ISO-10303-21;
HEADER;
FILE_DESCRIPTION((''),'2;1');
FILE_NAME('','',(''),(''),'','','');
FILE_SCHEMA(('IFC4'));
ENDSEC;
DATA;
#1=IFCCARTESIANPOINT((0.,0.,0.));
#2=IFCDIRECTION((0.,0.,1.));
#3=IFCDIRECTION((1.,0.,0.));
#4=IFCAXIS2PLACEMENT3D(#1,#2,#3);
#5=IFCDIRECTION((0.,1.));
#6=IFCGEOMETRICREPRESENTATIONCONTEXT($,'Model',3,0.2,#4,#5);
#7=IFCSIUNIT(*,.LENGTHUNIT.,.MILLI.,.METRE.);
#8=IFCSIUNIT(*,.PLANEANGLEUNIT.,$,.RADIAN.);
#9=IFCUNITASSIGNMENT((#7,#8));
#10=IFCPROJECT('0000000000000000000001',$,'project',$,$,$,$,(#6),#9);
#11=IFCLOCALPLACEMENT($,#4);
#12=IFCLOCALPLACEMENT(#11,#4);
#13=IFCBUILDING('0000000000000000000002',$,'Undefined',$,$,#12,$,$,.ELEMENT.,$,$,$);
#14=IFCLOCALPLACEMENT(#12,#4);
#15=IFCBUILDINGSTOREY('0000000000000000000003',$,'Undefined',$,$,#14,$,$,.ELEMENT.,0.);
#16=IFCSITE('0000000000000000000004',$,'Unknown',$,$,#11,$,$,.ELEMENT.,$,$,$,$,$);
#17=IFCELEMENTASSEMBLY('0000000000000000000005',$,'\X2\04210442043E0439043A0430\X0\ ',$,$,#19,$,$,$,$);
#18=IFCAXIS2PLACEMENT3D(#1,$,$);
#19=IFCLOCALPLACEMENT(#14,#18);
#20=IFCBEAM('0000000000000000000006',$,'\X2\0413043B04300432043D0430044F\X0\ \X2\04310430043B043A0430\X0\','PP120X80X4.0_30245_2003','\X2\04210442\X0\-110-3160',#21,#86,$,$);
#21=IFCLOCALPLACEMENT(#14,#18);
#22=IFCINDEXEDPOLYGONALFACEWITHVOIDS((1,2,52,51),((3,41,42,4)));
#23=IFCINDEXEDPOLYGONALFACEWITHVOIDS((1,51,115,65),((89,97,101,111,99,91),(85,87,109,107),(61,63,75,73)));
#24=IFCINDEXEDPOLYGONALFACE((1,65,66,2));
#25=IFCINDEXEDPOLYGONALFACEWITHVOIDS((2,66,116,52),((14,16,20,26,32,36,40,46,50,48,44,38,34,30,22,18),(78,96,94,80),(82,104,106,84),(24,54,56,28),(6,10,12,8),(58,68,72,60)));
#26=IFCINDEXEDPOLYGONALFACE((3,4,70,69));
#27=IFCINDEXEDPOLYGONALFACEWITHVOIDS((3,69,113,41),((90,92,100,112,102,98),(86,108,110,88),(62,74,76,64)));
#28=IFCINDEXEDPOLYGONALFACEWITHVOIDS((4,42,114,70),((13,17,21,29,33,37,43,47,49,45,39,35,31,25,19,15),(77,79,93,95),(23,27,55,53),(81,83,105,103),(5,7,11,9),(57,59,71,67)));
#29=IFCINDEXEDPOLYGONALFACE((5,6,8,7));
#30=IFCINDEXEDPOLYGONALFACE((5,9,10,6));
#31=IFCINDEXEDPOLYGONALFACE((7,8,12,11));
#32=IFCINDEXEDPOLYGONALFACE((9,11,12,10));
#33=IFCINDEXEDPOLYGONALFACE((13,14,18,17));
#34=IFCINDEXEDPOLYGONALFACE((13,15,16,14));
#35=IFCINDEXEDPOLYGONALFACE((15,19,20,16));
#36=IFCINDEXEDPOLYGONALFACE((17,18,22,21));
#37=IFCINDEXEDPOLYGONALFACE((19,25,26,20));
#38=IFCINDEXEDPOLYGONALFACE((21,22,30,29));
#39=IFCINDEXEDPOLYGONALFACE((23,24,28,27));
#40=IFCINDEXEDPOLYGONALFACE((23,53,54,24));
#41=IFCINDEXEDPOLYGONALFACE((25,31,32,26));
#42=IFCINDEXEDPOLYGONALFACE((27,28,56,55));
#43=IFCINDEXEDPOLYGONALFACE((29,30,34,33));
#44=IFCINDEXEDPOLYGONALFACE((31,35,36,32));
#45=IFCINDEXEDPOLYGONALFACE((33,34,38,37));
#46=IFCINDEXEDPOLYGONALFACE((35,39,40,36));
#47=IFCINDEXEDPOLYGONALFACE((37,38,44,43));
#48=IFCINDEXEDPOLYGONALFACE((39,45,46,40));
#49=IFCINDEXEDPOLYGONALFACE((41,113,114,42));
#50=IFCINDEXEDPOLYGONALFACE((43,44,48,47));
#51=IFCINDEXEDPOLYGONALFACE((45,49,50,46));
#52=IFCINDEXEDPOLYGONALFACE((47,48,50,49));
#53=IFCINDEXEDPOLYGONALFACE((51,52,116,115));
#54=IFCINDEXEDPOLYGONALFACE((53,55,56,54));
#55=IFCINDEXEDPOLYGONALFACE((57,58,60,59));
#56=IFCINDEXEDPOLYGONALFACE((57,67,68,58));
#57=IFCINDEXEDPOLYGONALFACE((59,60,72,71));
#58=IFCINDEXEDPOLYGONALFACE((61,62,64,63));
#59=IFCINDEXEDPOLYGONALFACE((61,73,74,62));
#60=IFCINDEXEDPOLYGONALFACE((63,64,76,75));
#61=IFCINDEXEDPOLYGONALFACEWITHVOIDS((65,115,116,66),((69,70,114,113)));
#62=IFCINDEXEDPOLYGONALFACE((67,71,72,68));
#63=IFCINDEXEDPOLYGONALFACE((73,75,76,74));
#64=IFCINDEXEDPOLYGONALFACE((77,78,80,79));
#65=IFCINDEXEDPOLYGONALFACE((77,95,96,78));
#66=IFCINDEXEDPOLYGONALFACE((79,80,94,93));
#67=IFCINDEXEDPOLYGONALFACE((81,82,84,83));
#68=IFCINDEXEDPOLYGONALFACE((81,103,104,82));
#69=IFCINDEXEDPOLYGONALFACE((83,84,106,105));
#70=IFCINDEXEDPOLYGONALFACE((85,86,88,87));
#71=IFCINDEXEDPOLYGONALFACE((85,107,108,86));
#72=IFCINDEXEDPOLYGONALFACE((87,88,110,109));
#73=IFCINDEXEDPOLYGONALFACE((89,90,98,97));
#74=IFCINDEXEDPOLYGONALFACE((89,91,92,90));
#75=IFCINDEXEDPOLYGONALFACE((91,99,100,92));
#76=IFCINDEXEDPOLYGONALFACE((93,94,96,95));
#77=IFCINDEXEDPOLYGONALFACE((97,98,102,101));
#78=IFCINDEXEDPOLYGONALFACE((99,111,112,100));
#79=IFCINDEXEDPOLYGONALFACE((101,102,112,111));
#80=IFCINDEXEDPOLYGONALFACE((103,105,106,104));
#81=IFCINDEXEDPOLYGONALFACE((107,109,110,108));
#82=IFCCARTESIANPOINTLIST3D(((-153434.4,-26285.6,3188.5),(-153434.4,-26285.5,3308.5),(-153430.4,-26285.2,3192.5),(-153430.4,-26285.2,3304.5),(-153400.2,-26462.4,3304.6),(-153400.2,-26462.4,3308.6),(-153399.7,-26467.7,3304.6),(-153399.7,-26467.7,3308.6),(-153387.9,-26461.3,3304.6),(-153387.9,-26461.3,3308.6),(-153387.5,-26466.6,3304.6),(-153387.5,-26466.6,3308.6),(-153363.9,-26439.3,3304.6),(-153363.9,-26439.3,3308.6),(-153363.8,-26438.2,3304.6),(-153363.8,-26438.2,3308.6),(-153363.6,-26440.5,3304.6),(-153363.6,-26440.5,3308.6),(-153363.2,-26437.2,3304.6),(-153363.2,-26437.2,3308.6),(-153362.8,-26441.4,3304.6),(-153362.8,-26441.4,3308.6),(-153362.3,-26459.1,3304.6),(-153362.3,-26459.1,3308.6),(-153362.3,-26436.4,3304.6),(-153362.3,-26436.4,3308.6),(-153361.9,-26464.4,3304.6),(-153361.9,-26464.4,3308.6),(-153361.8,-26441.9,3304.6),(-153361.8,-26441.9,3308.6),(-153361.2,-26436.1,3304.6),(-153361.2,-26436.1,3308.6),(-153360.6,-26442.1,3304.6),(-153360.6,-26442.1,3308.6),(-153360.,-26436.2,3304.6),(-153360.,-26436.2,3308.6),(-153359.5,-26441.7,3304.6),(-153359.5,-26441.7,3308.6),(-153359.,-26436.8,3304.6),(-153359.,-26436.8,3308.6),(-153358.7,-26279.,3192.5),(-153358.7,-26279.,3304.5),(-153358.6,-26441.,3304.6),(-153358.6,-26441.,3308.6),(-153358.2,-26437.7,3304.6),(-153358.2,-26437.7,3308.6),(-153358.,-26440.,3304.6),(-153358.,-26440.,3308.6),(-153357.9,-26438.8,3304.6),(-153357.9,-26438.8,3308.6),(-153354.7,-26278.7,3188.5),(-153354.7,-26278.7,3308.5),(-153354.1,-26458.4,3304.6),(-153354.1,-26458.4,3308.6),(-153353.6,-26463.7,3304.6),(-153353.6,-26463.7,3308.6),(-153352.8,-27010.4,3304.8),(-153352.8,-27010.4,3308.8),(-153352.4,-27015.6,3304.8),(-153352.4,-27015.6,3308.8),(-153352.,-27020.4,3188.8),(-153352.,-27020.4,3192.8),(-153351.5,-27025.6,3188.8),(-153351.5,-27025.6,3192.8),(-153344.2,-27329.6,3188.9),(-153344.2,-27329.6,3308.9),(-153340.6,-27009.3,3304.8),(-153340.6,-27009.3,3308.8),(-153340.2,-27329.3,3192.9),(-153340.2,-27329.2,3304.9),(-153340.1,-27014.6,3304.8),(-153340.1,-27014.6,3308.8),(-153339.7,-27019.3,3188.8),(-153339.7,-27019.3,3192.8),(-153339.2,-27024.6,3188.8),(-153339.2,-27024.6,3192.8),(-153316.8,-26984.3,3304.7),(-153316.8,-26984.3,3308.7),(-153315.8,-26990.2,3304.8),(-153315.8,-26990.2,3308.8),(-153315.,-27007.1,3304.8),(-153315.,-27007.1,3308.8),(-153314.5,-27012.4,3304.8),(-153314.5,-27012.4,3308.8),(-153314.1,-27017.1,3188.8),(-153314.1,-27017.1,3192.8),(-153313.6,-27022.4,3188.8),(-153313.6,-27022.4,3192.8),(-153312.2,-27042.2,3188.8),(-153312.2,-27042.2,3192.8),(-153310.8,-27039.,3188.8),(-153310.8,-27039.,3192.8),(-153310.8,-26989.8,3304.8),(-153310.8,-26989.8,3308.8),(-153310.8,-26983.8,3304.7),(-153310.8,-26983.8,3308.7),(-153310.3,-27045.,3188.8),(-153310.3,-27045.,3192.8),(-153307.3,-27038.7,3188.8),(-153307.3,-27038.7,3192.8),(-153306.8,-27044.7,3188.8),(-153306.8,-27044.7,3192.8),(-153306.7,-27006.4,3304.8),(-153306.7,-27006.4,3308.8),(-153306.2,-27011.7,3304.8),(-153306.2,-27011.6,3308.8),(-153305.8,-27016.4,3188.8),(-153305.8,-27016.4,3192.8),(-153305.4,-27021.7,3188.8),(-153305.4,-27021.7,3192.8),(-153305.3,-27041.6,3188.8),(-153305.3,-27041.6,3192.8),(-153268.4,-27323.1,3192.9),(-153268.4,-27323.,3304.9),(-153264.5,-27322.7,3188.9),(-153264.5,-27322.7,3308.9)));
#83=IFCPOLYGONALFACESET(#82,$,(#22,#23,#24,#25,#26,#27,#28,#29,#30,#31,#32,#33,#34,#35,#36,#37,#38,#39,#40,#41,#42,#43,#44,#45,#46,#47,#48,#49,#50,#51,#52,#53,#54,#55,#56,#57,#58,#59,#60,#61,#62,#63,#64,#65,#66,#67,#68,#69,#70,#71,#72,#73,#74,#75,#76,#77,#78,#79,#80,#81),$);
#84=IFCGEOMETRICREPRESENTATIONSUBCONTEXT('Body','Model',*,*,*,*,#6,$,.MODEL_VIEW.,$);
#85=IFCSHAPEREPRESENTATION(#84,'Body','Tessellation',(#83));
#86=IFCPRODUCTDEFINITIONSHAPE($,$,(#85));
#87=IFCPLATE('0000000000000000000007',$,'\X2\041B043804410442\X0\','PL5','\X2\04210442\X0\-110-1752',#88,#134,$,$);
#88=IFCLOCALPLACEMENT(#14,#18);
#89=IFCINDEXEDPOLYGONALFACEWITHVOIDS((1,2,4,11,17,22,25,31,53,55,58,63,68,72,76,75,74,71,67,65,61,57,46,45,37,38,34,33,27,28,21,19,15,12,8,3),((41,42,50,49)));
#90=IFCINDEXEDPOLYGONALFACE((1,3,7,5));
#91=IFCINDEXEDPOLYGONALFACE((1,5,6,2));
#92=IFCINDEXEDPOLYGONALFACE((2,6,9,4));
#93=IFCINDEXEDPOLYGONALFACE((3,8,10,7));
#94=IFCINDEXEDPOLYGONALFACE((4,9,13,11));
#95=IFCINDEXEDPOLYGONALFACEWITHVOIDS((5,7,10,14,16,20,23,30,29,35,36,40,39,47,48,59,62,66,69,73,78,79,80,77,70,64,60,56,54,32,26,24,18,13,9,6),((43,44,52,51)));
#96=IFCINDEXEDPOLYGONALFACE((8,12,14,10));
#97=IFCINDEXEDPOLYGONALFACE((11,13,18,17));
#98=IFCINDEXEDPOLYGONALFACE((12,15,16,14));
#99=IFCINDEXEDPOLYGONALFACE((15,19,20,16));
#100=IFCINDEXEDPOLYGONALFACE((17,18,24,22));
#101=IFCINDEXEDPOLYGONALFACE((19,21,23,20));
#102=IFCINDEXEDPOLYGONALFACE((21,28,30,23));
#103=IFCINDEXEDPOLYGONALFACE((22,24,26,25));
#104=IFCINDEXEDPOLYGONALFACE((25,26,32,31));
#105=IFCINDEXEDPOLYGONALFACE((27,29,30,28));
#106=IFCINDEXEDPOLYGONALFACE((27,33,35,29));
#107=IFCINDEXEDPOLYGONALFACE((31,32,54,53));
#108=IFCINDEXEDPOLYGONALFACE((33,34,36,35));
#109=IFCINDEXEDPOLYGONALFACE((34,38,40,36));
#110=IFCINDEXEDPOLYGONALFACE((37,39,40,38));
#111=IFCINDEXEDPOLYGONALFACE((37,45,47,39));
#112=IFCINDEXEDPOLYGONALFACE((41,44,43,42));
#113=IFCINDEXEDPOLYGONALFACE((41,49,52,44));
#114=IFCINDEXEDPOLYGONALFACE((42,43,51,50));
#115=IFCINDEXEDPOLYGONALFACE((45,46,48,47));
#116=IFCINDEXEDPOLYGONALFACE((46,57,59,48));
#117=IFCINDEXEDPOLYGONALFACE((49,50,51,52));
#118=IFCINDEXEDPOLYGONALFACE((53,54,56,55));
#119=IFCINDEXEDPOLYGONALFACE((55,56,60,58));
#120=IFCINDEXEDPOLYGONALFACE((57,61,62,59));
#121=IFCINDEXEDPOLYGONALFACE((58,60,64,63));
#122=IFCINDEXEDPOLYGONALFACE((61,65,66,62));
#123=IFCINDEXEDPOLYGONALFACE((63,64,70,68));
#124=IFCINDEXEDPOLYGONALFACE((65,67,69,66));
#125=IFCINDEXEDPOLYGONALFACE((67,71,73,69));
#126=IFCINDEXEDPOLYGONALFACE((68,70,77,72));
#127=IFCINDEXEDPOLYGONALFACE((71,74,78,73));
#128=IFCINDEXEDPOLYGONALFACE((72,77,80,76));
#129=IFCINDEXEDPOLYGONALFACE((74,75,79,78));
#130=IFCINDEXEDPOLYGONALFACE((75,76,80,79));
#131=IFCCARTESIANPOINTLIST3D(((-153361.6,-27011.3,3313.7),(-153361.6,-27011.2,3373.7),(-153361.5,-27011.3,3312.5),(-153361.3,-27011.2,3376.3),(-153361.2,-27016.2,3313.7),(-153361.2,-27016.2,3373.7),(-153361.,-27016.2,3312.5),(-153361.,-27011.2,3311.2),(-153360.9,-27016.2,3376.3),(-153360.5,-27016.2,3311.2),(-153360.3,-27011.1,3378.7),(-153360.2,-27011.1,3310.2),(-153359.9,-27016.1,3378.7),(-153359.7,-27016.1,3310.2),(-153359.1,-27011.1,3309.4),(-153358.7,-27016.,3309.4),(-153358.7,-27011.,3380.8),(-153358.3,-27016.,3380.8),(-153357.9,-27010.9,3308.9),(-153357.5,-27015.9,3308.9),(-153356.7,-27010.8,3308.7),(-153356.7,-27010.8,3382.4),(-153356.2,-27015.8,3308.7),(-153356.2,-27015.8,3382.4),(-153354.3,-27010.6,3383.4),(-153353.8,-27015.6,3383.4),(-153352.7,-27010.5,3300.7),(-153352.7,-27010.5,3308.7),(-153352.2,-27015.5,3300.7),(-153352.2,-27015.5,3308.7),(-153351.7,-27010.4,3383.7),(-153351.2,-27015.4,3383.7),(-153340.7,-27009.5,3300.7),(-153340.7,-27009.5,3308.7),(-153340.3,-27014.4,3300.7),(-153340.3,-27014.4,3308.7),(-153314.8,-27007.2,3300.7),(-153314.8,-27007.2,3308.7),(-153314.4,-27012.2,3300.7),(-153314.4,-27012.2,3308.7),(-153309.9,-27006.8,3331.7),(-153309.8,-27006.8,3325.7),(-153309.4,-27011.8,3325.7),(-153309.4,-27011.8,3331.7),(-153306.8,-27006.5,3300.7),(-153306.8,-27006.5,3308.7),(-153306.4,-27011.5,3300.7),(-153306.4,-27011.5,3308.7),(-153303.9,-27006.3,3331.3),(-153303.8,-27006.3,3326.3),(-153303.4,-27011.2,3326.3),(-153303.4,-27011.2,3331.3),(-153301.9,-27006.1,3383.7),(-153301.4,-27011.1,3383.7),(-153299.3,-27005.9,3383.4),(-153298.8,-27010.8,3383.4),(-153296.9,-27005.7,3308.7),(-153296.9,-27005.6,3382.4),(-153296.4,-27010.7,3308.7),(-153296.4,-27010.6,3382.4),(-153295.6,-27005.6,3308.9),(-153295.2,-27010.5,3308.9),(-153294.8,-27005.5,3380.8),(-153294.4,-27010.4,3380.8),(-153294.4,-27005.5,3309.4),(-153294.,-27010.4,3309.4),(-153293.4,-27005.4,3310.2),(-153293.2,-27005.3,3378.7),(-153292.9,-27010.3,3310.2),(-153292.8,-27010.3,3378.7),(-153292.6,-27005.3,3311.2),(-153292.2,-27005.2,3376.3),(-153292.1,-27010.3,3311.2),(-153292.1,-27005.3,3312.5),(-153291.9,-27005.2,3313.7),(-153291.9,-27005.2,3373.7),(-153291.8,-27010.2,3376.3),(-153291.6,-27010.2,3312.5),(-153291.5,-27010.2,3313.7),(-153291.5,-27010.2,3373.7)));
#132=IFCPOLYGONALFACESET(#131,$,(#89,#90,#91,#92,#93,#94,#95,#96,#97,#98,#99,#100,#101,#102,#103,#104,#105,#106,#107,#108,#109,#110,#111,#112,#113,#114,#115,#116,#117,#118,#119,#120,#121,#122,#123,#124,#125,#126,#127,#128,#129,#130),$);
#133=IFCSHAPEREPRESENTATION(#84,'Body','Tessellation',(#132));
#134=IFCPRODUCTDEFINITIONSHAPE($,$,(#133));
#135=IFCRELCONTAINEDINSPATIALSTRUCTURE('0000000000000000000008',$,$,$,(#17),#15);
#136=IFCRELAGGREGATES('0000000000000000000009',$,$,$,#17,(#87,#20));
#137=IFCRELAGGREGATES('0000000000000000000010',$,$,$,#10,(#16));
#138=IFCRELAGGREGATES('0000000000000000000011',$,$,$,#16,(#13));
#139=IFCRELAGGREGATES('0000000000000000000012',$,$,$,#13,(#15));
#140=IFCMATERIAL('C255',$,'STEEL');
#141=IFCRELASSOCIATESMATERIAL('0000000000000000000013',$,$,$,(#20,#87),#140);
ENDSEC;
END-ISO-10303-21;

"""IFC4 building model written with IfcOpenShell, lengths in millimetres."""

from ifc_helpers import new_model, si_unit, direction, frame, origin_with_axes, place, context, subcontext, project, spatial, line, arc, indexed_curve, outline, extrude, material, element, aggregate, save


model = new_model("IFC4")

# Units and contexts
model_context = context("Model", 3, precision=0.2, world=origin_with_axes(), true_north=direction((0.0, 1.0)))
body_context = subcontext(model_context, "Body", "Model", "MODEL_VIEW")
ifc_project = project(units=[si_unit("LENGTHUNIT", "METRE", prefix="MILLI"), si_unit("PLANEANGLEUNIT", "RADIAN")], contexts=[model_context])

# Site, building, storey
site_placement = place(None, origin_with_axes())
site = spatial("IfcSite", under=ifc_project, at=site_placement, Name="Unknown", CompositionType="ELEMENT")
building_placement = place(site_placement, origin_with_axes())
building = spatial("IfcBuilding", under=site, at=building_placement, Name="Undefined", CompositionType="ELEMENT")
storey_placement = place(building_placement, origin_with_axes())
storey = spatial("IfcBuildingStorey", under=building, at=storey_placement, Name="Undefined", CompositionType="ELEMENT", Elevation=0.0)

# Element assembly, beam, voiding features, plate
assembly_1_placement = place(storey_placement, frame((-153388.9, -26231.4, 131.5), z_axis=(-0.086114, 0.996285, 0.0), x_axis=(0.0, 0.0, 1.0)))
assembly_1 = element("IfcElementAssembly", 1, at=assembly_1_placement, inside=storey, Name="Стойка ")
ifc_material_1 = material(Name="C255", Category="STEEL")
beam_placement = place(assembly_1_placement, frame((3117.0, -10.0, -50.0), z_axis=(0.000024, -1.0, -0.000005), x_axis=(0.000303, 0.0, -1.0)))
beam = element("IfcBeam", 2, at=beam_placement, material=ifc_material_1, Name="Главная балка", Description="PP120X80X4.0_30245_2003", ObjectType="Ст-110-3160", context=body_context, shape_type="SolidModel", body=[
    extrude(outline(indexed_curve([(-40.0, -60.0), (40.0, -60.0), (40.0, 60.0), (-40.0, 60.0)], segments=[line(1, 2, 3, 4, 1)]), holes=[indexed_curve([(-36.0, -56.0), (-36.0, 56.0), (36.0, 56.0), (36.0, -56.0)], segments=[line(1, 2, 3, 4, 1)])]), frame((0.0, 0.0, 0.0), z_axis=(-1.0, 0.0, 0.0), x_axis=(0.0, 0.0, 1.0)), (0.0, 0.0, -1.0), 1047.9),
])
voiding_feature_1_placement = place(beam_placement, frame((731.8, 62.0, -25.2), z_axis=(-1.0, 0.0, 0.0), x_axis=(0.0, -1.0, 0.0)))
element("IfcVoidingFeature", 3, at=voiding_feature_1_placement, cuts=beam, Name="CUTPART", ObjectType="(?)", PredefinedType="HOLE", context=body_context, shape_type="SolidModel", body=[
    extrude(outline(indexed_curve([(0.0, 0.0), (10.0, 0.0), (10.0, 8.3), (0.0, 8.3)], segments=[line(1, 2, 3, 4, 1)])), frame((0.0, 0.0, 2.6), z_axis=(0.0, 0.0, 1.0), x_axis=(1.0, 0.0, 0.0)), (0.0, 0.0, -1.0), 5.3),
])
voiding_feature_2_placement = place(beam_placement, frame((731.8, 52.0, 8.8), z_axis=(-1.0, 0.0, 0.0), x_axis=(0.0, 0.0, 1.0)))
element("IfcVoidingFeature", 4, at=voiding_feature_2_placement, cuts=beam, Name="CUTPART", ObjectType="(?)", PredefinedType="HOLE", context=body_context, shape_type="SolidModel", body=[
    extrude(outline(indexed_curve([(0.0, 0.0), (12.3, 0.0), (12.3, 10.0), (0.0, 10.0)], segments=[line(1, 2, 3, 4, 1)])), frame((0.0, 0.0, 2.6), z_axis=(0.0, 0.0, 1.0), x_axis=(1.0, 0.0, 0.0)), (0.0, 0.0, -1.0), 5.3),
])
voiding_feature_3_placement = place(beam_placement, frame((709.3, 66.0, -20.0), z_axis=(0.0, 0.0, -1.0), x_axis=(0.0, -1.0, 0.0)))
element("IfcVoidingFeature", 5, at=voiding_feature_3_placement, cuts=beam, Name="Балка", ObjectType="(?)", PredefinedType="HOLE", context=body_context, shape_type="SolidModel", body=[
    extrude(outline(indexed_curve([(2.5, -3.0), (3.0, 3.0), (-3.0, 3.0), (-2.5, -3.0)], segments=[line(1, 2, 3, 4, 1)])), frame((0.0, 0.0, 0.0), z_axis=(-1.0, 0.0, 0.0), x_axis=(0.0, 0.0, 1.0)), (0.0, 0.0, -1.0), 12.0),
])
voiding_feature_4_placement = place(beam_placement, frame((181.8, 62.0, -25.2), z_axis=(-1.0, 0.0, 0.0), x_axis=(0.0, -1.0, 0.0)))
element("IfcVoidingFeature", 6, at=voiding_feature_4_placement, cuts=beam, Name="CUTPART", ObjectType="(?)", PredefinedType="HOLE", context=body_context, shape_type="SolidModel", body=[
    extrude(outline(indexed_curve([(0.0, 0.0), (10.0, 0.0), (10.0, 8.3), (0.0, 8.3)], segments=[line(1, 2, 3, 4, 1)])), frame((0.0, 0.0, 2.6), z_axis=(0.0, 0.0, 1.0), x_axis=(1.0, 0.0, 0.0)), (0.0, 0.0, -1.0), 5.3),
])
voiding_feature_5_placement = place(beam_placement, frame((181.8, 52.0, 8.8), z_axis=(-1.0, 0.0, 0.0), x_axis=(0.0, 0.0, 1.0)))
element("IfcVoidingFeature", 7, at=voiding_feature_5_placement, cuts=beam, Name="CUTPART", ObjectType="(?)", PredefinedType="HOLE", context=body_context, shape_type="SolidModel", body=[
    extrude(outline(indexed_curve([(0.0, 0.0), (12.3, 0.0), (12.3, 10.0), (0.0, 10.0)], segments=[line(1, 2, 3, 4, 1)])), frame((0.0, 0.0, 2.6), z_axis=(0.0, 0.0, 1.0), x_axis=(1.0, 0.0, 0.0)), (0.0, 0.0, -1.0), 5.3),
])
voiding_feature_6_placement = place(beam_placement, frame((159.3, 66.0, -20.0), z_axis=(0.0, 0.0, -1.0), x_axis=(0.0, -1.0, 0.0)))
element("IfcVoidingFeature", 8, at=voiding_feature_6_placement, cuts=beam, Name="Балка", ObjectType="(?)", PredefinedType="HOLE", context=body_context, shape_type="SolidModel", body=[
    extrude(outline(indexed_curve([(3.0, 0.0), (2.8, 1.1), (2.1, 2.1), (1.1, 2.8), (0.0, 3.0), (-1.1, 2.8), (-2.1, 2.1), (-2.8, 1.1), (-3.0, 0.0), (-2.8, -1.1), (-2.1, -2.1), (-1.1, -2.8), (0.0, -3.0), (1.1, -2.8), (2.1, -2.1), (2.8, -1.1)], segments=[line(1, 2, 3, 4, 5, 6, 7, 8, 9, 10, 11, 12, 13, 14, 15, 16, 1)])), frame((0.0, 0.0, 0.0), z_axis=(-1.0, 0.0, 0.0), x_axis=(0.0, 0.0, 1.0)), (0.0, 0.0, -1.0), 12.0),
])
voiding_feature_7_placement = place(beam_placement, frame((741.8, -61.9, -25.2), z_axis=(1.0, 0.0, 0.0), x_axis=(0.0, 1.0, 0.0)))
element("IfcVoidingFeature", 9, at=voiding_feature_7_placement, cuts=beam, Name="CUTPART", ObjectType="(?)", PredefinedType="HOLE", context=body_context, shape_type="SolidModel", body=[
    extrude(outline(indexed_curve([(0.0, 0.0), (10.0, 0.0), (10.0, 8.3), (0.0, 8.3)], segments=[line(1, 2, 3, 4, 1)])), frame((0.0, 0.0, 2.6), z_axis=(0.0, 0.0, 1.0), x_axis=(1.0, 0.0, 0.0)), (0.0, 0.0, -1.0), 5.3),
])
voiding_feature_8_placement = place(beam_placement, frame((741.8, -51.9, 8.8), z_axis=(1.0, 0.0, 0.0), x_axis=(0.0, 0.0, 1.0)))
element("IfcVoidingFeature", 10, at=voiding_feature_8_placement, cuts=beam, Name="CUTPART", ObjectType="(?)", PredefinedType="HOLE", context=body_context, shape_type="SolidModel", body=[
    extrude(outline(indexed_curve([(0.0, 0.0), (12.3, 0.0), (12.3, 10.0), (0.0, 10.0)], segments=[line(1, 2, 3, 4, 1)])), frame((0.0, 0.0, 2.6), z_axis=(0.0, 0.0, 1.0), x_axis=(1.0, 0.0, 0.0)), (0.0, 0.0, -1.0), 5.3),
])
voiding_feature_9_placement = place(beam_placement, frame((764.3, -65.9, -20.0), z_axis=(0.0, 0.0, -1.0), x_axis=(0.0, 1.0, 0.0)))
element("IfcVoidingFeature", 11, at=voiding_feature_9_placement, cuts=beam, Name="Балка", ObjectType="(?)", PredefinedType="HOLE", context=body_context, shape_type="SolidModel", body=[
    extrude(outline(indexed_curve([(1.7, -3.0), (3.5, 0.0), (1.7, 3.0), (-1.7, 3.0), (-3.5, 0.0), (-1.7, -3.0)], segments=[line(1, 2, 3, 4, 5, 6, 1)])), frame((0.0, 0.0, 0.0), z_axis=(-1.0, 0.0, 0.0), x_axis=(0.0, 0.0, 1.0)), (0.0, 0.0, -1.0), 12.0),
])
plate_1_placement = place(assembly_1_placement, frame((3252.2, 30.0, -781.8), z_axis=(0.000357, 0.0, -1.0), x_axis=(-0.00003, -1.0, 0.0)))
plate_1 = element("IfcPlate", 12, at=plate_1_placement, material=ifc_material_1, Name="Лист", Description="PL5", ObjectType="Ст-110-1752", context=body_context, shape_type="SolidModel", body=[
    extrude(outline(indexed_curve([(0.0, 10.0), (2.9, 2.9), (10.0, 0.0), (60.0, 0.0), (67.1, 2.9), (70.0, 10.0), (70.0, 70.0), (68.5, 73.5), (65.0, 75.0), (61.0, 75.0), (61.0, 83.0), (49.0, 83.0), (49.0, 75.0), (23.0, 75.0), (23.0, 83.0), (15.0, 83.0), (15.0, 75.0), (5.0, 75.0), (1.5, 73.5), (0.0, 70.0)], segments=[arc(1, 2, 3), line(3, 4), arc(4, 5, 6), line(6, 7), arc(7, 8, 9), line(9, 10, 11, 12, 13, 14, 15, 16, 17, 18), arc(18, 19, 20), line(20, 1)])), frame((0.0, 0.0, 2.5), z_axis=(0.0, 0.0, 1.0), x_axis=(1.0, 0.0, 0.0)), (0.0, 0.0, -1.0), 5.0),
])
voiding_feature_10_placement = place(plate_1_placement, frame((15.0, 55.0, 10.0), z_axis=(0.007997, -0.999968, -0.000026), x_axis=(0.0, 0.000026, -1.0)))
element("IfcVoidingFeature", 13, at=voiding_feature_10_placement, cuts=plate_1, Name="Балка", ObjectType="(?)", PredefinedType="HOLE", context=body_context, shape_type="SolidModel", body=[
    extrude(outline(indexed_curve([(2.5, -3.0), (3.0, 3.0), (-3.0, 3.0), (-2.5, -3.0)], segments=[line(1, 2, 3, 4, 1)])), frame((0.0, 0.0, 0.0), z_axis=(-1.0, 0.0, 0.0), x_axis=(0.0, 0.0, 1.0)), (0.0, 0.0, -1.0), 20.0),
])

aggregate(assembly_1, [plate_1, beam])

save(model, "model.ifc")
